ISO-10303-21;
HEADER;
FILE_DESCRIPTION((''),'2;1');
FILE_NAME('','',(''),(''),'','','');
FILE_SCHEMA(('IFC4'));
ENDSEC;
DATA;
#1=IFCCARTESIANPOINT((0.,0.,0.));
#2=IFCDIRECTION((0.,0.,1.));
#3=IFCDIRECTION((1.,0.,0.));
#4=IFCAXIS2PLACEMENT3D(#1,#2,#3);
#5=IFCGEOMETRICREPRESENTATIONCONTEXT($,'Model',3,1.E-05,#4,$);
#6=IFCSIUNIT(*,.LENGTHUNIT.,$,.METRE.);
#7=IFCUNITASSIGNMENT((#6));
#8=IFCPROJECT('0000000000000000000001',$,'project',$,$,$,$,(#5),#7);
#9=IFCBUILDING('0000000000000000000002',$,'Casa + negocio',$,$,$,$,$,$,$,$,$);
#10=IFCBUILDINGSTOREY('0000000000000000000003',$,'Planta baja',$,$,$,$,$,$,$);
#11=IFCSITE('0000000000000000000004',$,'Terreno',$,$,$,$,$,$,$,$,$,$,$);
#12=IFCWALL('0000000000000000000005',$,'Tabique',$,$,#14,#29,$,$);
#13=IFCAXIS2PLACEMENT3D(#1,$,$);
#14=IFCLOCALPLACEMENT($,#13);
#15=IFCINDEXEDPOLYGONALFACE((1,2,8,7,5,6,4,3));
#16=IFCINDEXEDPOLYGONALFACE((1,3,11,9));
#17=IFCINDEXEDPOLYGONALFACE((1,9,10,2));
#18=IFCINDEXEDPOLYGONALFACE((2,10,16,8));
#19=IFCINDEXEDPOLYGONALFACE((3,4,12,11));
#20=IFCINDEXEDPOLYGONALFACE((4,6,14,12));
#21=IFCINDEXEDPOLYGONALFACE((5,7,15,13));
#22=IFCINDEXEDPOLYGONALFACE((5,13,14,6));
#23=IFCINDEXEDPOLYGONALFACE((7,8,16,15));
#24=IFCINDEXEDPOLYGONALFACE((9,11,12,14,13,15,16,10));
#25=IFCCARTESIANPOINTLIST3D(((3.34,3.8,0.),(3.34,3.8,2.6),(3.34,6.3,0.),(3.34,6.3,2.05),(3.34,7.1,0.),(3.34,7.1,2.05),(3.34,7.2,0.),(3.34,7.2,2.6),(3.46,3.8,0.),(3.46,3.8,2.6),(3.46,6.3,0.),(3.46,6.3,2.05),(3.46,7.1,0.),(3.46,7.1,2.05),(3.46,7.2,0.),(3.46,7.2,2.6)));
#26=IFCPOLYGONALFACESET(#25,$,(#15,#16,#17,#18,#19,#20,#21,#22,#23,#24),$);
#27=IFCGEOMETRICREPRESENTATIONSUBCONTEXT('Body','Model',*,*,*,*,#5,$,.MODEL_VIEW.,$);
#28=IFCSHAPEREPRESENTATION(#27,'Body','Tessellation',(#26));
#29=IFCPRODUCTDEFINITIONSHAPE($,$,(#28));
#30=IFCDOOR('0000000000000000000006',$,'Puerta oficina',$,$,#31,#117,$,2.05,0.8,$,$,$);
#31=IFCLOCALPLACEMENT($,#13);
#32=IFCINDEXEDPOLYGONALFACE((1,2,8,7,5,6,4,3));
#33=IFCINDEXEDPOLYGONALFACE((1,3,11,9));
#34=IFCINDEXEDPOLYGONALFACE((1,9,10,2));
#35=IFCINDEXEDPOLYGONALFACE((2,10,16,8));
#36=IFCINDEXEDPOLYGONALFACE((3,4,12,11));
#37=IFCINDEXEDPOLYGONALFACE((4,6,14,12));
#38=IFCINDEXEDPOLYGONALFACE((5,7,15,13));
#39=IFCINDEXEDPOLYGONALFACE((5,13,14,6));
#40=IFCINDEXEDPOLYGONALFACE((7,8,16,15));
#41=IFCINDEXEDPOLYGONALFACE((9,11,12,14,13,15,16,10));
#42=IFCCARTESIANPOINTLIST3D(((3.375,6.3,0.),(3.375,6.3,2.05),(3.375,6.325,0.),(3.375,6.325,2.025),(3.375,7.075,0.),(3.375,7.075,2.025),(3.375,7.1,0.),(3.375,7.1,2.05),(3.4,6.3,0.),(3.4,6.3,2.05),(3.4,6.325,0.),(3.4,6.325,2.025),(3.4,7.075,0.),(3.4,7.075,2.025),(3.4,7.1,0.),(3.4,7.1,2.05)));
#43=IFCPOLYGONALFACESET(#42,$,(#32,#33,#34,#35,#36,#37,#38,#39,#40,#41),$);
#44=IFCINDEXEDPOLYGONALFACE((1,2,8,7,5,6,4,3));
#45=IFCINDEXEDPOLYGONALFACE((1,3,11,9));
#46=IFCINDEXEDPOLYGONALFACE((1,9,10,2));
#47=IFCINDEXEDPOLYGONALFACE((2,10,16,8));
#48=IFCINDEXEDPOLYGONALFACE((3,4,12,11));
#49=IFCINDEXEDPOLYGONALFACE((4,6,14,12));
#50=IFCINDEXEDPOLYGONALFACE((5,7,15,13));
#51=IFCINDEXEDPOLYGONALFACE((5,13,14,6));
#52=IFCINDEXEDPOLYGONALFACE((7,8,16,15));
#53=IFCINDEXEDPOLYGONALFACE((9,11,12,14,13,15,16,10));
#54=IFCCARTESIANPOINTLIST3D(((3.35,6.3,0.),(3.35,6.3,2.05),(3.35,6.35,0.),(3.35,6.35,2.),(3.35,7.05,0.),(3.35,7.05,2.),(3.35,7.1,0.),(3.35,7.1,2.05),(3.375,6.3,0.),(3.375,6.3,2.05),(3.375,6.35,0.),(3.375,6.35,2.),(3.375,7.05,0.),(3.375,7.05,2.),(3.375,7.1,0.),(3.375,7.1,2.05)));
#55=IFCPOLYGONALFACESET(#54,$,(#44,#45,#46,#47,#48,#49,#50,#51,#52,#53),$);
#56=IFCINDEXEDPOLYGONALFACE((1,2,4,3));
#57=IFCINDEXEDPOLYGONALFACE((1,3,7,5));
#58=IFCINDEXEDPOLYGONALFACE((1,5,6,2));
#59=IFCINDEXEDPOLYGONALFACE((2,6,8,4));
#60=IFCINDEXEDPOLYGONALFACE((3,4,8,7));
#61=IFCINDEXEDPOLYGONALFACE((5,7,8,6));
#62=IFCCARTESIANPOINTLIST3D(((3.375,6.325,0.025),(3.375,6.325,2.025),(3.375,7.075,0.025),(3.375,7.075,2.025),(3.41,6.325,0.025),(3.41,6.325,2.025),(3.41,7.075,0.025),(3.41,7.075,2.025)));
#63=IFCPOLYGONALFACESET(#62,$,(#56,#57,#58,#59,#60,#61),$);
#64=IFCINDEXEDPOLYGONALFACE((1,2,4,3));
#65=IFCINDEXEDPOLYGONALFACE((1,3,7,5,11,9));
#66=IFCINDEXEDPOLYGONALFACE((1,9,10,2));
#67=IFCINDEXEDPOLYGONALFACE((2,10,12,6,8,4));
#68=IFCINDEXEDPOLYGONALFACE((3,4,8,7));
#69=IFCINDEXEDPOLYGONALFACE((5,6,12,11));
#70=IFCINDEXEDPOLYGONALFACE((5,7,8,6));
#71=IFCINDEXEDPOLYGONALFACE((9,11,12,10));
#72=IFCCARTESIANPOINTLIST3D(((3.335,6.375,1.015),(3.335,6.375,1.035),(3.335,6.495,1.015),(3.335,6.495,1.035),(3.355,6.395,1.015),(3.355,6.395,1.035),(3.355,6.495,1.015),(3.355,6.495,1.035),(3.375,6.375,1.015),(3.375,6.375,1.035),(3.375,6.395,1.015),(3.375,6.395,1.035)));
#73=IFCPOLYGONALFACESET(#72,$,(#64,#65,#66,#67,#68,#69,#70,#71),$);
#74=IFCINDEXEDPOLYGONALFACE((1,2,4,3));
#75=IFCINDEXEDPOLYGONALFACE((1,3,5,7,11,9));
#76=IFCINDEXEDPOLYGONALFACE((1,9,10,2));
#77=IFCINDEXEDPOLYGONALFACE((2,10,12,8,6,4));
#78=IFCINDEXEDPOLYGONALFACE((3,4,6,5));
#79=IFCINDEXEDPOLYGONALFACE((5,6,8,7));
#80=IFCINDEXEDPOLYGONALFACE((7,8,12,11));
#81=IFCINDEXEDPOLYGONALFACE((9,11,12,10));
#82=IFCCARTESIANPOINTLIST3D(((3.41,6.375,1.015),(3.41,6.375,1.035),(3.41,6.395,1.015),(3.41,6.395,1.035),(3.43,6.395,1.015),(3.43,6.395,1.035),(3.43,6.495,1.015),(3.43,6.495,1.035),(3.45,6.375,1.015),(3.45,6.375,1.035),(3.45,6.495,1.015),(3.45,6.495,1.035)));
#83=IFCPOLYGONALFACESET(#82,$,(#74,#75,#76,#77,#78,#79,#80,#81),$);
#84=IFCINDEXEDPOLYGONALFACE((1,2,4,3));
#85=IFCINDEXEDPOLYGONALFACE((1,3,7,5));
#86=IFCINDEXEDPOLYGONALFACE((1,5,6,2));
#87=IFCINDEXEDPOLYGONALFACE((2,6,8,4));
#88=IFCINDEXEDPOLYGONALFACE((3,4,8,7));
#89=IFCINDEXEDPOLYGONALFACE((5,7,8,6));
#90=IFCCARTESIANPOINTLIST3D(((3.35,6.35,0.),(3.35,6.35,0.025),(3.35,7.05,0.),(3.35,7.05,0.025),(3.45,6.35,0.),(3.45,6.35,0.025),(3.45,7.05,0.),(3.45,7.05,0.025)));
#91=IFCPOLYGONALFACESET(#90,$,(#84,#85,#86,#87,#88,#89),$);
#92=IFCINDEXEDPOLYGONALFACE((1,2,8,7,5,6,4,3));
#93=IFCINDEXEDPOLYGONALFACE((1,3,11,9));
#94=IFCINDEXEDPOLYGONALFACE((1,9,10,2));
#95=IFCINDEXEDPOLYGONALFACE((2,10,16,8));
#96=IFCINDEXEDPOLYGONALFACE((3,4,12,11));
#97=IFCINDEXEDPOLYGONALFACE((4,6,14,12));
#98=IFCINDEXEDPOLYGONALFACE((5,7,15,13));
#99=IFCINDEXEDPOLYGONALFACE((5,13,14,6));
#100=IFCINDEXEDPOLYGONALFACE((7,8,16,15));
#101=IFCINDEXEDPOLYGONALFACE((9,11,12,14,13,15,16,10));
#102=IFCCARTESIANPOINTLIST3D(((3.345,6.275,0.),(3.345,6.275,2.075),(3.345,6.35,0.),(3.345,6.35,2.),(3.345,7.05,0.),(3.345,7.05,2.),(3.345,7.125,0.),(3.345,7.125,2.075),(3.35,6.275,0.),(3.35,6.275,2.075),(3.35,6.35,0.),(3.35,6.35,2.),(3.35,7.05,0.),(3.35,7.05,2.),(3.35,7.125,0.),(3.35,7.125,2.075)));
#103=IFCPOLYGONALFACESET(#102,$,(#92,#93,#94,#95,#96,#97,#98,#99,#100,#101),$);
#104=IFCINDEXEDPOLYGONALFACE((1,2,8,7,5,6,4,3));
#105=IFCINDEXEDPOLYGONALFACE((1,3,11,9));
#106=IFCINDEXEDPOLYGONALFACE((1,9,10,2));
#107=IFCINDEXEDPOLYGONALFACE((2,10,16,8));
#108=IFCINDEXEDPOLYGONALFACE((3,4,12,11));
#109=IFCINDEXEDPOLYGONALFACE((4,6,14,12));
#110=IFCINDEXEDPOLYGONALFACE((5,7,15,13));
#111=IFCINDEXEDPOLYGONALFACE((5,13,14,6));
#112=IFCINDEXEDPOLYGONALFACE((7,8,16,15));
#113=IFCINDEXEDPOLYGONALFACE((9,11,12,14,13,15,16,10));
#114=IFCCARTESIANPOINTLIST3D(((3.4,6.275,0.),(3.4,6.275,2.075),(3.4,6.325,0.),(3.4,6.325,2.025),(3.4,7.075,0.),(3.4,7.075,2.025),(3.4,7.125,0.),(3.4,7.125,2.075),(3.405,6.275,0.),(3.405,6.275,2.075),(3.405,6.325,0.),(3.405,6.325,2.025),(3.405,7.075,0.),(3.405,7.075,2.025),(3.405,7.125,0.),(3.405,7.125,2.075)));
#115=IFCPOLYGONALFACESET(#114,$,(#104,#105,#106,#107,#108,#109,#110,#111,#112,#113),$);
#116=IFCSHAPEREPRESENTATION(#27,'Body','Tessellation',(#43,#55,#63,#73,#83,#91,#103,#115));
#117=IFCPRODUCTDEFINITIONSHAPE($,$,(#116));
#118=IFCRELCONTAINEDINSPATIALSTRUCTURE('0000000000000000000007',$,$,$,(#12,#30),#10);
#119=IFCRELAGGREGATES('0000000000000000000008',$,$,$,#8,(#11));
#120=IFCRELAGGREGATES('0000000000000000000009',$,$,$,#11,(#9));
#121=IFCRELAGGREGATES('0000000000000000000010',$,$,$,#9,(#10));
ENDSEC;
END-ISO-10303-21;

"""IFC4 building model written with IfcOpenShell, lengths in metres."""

from ifc_helpers import new_model, si_unit, frame, origin_with_axes, place, context, subcontext, project, spatial, line, indexed_curve, outline, extrude, element, fill, save


model = new_model("IFC4")

# Units and contexts
model_context = context("Model", 3, precision=1e-05, world=origin_with_axes())
body_context = subcontext(model_context, "Body", "Model", "MODEL_VIEW")
ifc_project = project(units=[si_unit("LENGTHUNIT", "METRE")], contexts=[model_context])

# Site, building, storey
site = spatial("IfcSite", under=ifc_project, Name="Terreno")
building = spatial("IfcBuilding", under=site, Name="Casa + negocio")
storey = spatial("IfcBuildingStorey", under=building, Name="Planta baja")

# Wall, opening, door
wall_1_placement = place(None, frame((3.4, 7.2, 0.0), z_axis=(0.0, 0.0, 1.0), x_axis=(0.0, -1.0, 0.0)))
wall_1 = element("IfcWall", 1, at=wall_1_placement, inside=storey, Name="Tabique", context=body_context, shape_type="SweptSolid", body=[
    extrude(outline(indexed_curve([(0.0, 0.0), (0.0, 0.12), (3.4, 0.12), (3.4, 0.0), (0.0, 0.0)], self_intersect=False)), frame((0.0, -0.06, 0.0), z_axis=(0.0, 0.0, 1.0), x_axis=(1.0, 0.0, 0.0)), (0.0, 0.0, 1.0), 2.6),
])
opening_1_placement = place(wall_1_placement, frame((0.1, 0.0, 0.0), z_axis=(0.0, 0.0, 1.0), x_axis=(1.0, 0.0, 0.0)))
opening_1 = element("IfcOpeningElement", 2, at=opening_1_placement, cuts=wall_1, context=body_context, shape_type="SweptSolid", body=[
    extrude(outline(indexed_curve([(0.0, 0.0), (0.0, 0.22), (0.8, 0.22), (0.8, 0.0), (0.0, 0.0)], self_intersect=False)), frame((0.0, -0.11, 0.0), z_axis=(0.0, 0.0, 1.0), x_axis=(1.0, 0.0, 0.0)), (0.0, 0.0, 1.0), 2.05),
])
door_1_placement = place(opening_1_placement, frame((0.0, -0.05, 0.0), z_axis=(0.0, 0.0, 1.0), x_axis=(1.0, 0.0, 0.0)))
door_1 = element("IfcDoor", 3, at=door_1_placement, inside=storey, Name="Puerta oficina", OverallHeight=2.05, OverallWidth=0.8, context=body_context, shape_type="SweptSolid", body=[
    extrude(outline(indexed_curve([(0.0, 0.0), (0.0, 2.05), (0.8, 2.05), (0.8, 0.0), (0.775, 0.0), (0.775, 2.025), (0.025, 2.025), (0.025, 0.0)], segments=[line(1, 2, 3, 4, 5, 6, 7, 8, 1)])), frame((0.0, 0.025, 0.0), z_axis=(0.0, -1.0, 0.0), x_axis=(1.0, 0.0, 0.0)), (0.0, 0.0, -1.0), 0.025),
    extrude(outline(indexed_curve([(0.0, 0.0), (0.0, 2.05), (0.8, 2.05), (0.8, 0.0), (0.75, 0.0), (0.75, 2.0), (0.05, 2.0), (0.05, 0.0)], segments=[line(1, 2, 3, 4, 5, 6, 7, 8, 1)])), frame((0.0, 0.0, 0.0), z_axis=(0.0, -1.0, 0.0), x_axis=(1.0, 0.0, 0.0)), (0.0, 0.0, -1.0), 0.025),
    extrude(outline(indexed_curve([(0.0, 0.0), (0.75, 0.0), (0.75, 0.035), (0.0, 0.035)], segments=[line(1, 2, 3, 4, 1)])), frame((0.025, 0.025, 0.025), z_axis=(0.0, 0.0, 1.0), x_axis=(1.0, 0.0, 0.0)), (0.0, 0.0, 1.0), 2.0),
    extrude(outline(indexed_curve([(0.0, 0.0), (0.0, -0.04), (-0.12, -0.04), (-0.12, -0.02), (-0.02, -0.02), (-0.02, 0.0)], segments=[line(1, 2, 3, 4, 5, 6, 1)])), frame((0.725, 0.025, 1.015), z_axis=(0.0, 0.0, 1.0), x_axis=(1.0, 0.0, 0.0)), (0.0, 0.0, 1.0), 0.02),
    extrude(outline(indexed_curve([(0.0, 0.0), (0.0, 0.04), (-0.12, 0.04), (-0.12, 0.02), (-0.02, 0.02), (-0.02, 0.0)], segments=[line(1, 2, 3, 4, 5, 6, 1)])), frame((0.725, 0.06, 1.015), z_axis=(0.0, 0.0, 1.0), x_axis=(1.0, 0.0, 0.0)), (0.0, 0.0, 1.0), 0.02),
    extrude(outline(indexed_curve([(0.0, 0.0), (0.7, 0.0), (0.7, 0.1), (0.0, 0.1)], segments=[line(1, 2, 3, 4, 1)])), frame((0.05, 0.0, 0.0), z_axis=(0.0, 0.0, 1.0), x_axis=(1.0, 0.0, 0.0)), (0.0, 0.0, 1.0), 0.025),
    extrude(outline(indexed_curve([(0.0, 0.0), (0.0, 2.075), (0.85, 2.075), (0.85, 0.0), (0.775, 0.0), (0.775, 2.0), (0.075, 2.0), (0.075, 0.0)], segments=[line(1, 2, 3, 4, 5, 6, 7, 8, 1)])), frame((-0.025, -0.005, 0.0), z_axis=(0.0, -1.0, 0.0), x_axis=(1.0, 0.0, 0.0)), (0.0, 0.0, -1.0), 0.005),
    extrude(outline(indexed_curve([(0.0, 0.0), (0.0, 2.075), (0.85, 2.075), (0.85, 0.0), (0.8, 0.0), (0.8, 2.025), (0.05, 2.025), (0.05, 0.0)], segments=[line(1, 2, 3, 4, 5, 6, 7, 8, 1)])), frame((-0.025, 0.05, 0.0), z_axis=(0.0, -1.0, 0.0), x_axis=(1.0, 0.0, 0.0)), (0.0, 0.0, -1.0), 0.005),
])
fill(opening_1, door_1)

save(model, "model.ifc")
